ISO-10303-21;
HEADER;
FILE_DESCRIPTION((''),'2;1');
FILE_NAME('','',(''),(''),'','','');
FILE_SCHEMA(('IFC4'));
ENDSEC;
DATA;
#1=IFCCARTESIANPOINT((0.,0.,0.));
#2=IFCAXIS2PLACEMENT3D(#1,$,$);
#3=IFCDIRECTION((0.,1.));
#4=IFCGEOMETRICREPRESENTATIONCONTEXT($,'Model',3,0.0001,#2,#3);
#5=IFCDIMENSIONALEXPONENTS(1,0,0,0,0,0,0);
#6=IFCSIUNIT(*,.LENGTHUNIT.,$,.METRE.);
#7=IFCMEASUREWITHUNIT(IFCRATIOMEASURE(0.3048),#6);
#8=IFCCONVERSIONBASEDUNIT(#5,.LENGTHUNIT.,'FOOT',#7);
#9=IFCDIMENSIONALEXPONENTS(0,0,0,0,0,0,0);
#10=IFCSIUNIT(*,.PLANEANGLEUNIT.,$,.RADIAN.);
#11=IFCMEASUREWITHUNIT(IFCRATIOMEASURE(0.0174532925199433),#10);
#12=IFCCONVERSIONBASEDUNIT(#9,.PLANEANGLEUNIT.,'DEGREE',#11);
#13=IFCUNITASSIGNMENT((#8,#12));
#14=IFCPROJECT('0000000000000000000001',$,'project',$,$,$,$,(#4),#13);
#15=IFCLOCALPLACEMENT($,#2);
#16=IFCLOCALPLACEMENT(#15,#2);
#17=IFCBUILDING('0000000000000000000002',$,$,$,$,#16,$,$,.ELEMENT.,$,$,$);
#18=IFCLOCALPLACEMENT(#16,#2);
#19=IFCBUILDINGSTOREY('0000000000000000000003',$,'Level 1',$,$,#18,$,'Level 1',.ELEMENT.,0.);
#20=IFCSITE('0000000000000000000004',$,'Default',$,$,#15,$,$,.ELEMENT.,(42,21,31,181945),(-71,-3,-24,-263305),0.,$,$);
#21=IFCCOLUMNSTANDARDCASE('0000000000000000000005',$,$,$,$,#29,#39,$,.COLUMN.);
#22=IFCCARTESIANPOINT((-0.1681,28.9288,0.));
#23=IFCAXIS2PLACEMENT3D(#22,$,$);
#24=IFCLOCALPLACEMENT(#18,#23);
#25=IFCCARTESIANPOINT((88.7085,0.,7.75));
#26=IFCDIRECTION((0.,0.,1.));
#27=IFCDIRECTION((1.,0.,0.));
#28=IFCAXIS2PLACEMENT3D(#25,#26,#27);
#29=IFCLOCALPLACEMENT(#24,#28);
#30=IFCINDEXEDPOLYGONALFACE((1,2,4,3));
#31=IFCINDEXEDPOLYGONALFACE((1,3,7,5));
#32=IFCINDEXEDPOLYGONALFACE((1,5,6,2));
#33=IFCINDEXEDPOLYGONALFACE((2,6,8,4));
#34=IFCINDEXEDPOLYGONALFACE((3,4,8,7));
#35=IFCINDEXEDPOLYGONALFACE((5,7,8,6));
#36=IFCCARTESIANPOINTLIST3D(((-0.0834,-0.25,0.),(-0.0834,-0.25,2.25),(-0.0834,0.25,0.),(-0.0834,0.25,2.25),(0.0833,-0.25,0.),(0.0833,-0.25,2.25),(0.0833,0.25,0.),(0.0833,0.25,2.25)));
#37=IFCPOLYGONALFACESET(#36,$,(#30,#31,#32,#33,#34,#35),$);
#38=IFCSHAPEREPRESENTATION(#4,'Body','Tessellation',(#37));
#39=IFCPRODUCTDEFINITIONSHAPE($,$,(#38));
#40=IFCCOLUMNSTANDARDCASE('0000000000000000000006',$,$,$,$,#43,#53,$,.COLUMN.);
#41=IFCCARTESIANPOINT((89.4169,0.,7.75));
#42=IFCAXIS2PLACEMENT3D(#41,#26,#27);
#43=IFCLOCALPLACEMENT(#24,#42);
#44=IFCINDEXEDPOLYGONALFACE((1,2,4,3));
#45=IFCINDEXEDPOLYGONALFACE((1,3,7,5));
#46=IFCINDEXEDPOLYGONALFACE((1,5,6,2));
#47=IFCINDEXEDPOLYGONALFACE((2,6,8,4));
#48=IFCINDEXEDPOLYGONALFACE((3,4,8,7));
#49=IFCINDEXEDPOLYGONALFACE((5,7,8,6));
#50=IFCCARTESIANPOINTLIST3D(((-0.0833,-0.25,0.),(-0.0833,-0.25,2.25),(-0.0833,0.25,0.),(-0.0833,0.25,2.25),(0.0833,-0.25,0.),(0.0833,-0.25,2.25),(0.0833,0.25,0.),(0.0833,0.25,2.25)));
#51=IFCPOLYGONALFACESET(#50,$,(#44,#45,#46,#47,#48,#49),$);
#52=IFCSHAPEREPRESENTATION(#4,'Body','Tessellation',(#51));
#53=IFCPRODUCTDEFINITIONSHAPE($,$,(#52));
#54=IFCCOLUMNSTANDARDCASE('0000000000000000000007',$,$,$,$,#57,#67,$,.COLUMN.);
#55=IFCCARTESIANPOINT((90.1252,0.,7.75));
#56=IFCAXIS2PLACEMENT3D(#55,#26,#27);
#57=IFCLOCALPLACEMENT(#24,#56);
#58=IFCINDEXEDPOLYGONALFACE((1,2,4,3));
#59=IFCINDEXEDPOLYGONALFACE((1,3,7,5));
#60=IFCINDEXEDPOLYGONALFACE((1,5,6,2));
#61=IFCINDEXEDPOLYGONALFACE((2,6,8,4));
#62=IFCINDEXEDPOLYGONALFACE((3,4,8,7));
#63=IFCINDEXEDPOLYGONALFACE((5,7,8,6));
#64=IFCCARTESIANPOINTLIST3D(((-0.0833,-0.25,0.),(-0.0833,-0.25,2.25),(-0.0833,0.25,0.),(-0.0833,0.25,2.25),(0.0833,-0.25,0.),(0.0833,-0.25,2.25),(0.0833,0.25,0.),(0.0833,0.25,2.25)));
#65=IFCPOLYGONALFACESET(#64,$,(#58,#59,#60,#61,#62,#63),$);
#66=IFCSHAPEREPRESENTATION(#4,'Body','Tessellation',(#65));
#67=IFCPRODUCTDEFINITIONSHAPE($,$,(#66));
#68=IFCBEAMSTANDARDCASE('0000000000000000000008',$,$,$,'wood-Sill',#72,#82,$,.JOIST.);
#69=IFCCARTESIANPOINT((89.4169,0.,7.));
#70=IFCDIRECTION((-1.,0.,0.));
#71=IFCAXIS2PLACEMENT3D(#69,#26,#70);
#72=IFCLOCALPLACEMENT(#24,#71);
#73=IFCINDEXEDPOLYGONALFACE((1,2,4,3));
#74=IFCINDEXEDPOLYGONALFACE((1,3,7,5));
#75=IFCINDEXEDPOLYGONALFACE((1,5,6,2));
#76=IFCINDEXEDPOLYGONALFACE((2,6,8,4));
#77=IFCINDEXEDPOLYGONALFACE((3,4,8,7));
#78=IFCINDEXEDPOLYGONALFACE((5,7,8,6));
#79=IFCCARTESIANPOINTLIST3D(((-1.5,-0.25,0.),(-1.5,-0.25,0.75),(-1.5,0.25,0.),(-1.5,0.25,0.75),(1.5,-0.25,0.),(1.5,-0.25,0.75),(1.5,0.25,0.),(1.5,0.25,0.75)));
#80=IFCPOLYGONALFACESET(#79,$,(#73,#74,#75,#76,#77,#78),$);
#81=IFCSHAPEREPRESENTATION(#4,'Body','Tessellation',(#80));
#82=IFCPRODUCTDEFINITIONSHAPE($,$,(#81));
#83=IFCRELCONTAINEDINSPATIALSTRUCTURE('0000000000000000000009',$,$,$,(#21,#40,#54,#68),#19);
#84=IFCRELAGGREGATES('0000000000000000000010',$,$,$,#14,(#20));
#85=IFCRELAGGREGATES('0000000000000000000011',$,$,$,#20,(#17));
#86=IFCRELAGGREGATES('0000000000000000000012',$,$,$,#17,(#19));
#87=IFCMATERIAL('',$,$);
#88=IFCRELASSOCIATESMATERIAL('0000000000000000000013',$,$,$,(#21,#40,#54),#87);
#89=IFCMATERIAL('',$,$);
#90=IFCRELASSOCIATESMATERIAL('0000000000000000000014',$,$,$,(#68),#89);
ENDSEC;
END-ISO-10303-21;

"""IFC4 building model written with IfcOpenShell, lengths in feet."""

from ifc_helpers import new_model, entity, si_unit, converted_unit, direction, frame, origin, place, context, project, spatial, rectangle, extrude, material, element, save


model = new_model("IFC4")

# Units and contexts
model_context = context("Model", 3, precision=0.0001, world=origin(), true_north=direction((0.0, 1.0)))
ifc_project = project(units=[converted_unit("LENGTHUNIT", "FOOT", entity("IfcRatioMeasure", 0.3048), si_unit("LENGTHUNIT", "METRE"), dimensions=[1, 0, 0, 0, 0, 0, 0]), converted_unit("PLANEANGLEUNIT", "DEGREE", entity("IfcRatioMeasure", 0.0174532925199433), si_unit("PLANEANGLEUNIT", "RADIAN"), dimensions=[0, 0, 0, 0, 0, 0, 0])], contexts=[model_context])

# Site, building, storey
site_placement = place(None, origin())
site = spatial("IfcSite", under=ifc_project, at=site_placement, Name="Default", CompositionType="ELEMENT", RefLatitude=(42, 21, 31, 181945), RefLongitude=(-71, -3, -24, -263305), RefElevation=0.0)
building_placement = place(site_placement, origin())
building = spatial("IfcBuilding", under=site, at=building_placement, CompositionType="ELEMENT")
storey_placement = place(building_placement, origin())
storey = spatial("IfcBuildingStorey", under=building, at=storey_placement, Name="Level 1", LongName="Level 1", CompositionType="ELEMENT", Elevation=0.0)

# Columns
ifc_material_1 = material(Name="")
placement = place(storey_placement, frame((-0.1681, 28.9288, 0.0)))
for number, where, z_axis, x_axis in (
    (1, (88.7085, 0.0, 7.75), (0.0, 0.0, 1.0), (1.0, 0.0, 0.0)),
    (2, (89.4169, 0.0, 7.75), (0.0, 0.0, 1.0), (1.0, 0.0, 0.0)),
    (3, (90.1252, 0.0, 7.75), (0.0, 0.0, 1.0), (1.0, 0.0, 0.0)),
):
    element("IfcColumnStandardCase", number, at=place(placement, frame(where, z_axis=z_axis, x_axis=x_axis)), inside=storey, material=ifc_material_1, PredefinedType="COLUMN", context=model_context, shape_type="SweptSolid", body=[
        extrude(rectangle(XDim=0.1667, YDim=0.5), origin(), (0.0, 0.0, 1.0), 2.25),
    ])

# Beam
ifc_material_2 = material(Name="")
for number, where, z_axis, x_axis in (
    (4, (89.4169, 0.0, 7.0), (0.0, 0.0, 1.0), (-1.0, 0.0, 0.0)),
):
    element("IfcBeamStandardCase", number, at=place(placement, frame(where, z_axis=z_axis, x_axis=x_axis)), inside=storey, material=ifc_material_2, ObjectType="wood-Sill", PredefinedType="JOIST", context=model_context, shape_type="SweptSolid", body=[
        extrude(rectangle(XDim=3.0, YDim=0.5), origin(), (0.0, 0.0, 1.0), 0.75),
    ])

save(model, "model.ifc")
